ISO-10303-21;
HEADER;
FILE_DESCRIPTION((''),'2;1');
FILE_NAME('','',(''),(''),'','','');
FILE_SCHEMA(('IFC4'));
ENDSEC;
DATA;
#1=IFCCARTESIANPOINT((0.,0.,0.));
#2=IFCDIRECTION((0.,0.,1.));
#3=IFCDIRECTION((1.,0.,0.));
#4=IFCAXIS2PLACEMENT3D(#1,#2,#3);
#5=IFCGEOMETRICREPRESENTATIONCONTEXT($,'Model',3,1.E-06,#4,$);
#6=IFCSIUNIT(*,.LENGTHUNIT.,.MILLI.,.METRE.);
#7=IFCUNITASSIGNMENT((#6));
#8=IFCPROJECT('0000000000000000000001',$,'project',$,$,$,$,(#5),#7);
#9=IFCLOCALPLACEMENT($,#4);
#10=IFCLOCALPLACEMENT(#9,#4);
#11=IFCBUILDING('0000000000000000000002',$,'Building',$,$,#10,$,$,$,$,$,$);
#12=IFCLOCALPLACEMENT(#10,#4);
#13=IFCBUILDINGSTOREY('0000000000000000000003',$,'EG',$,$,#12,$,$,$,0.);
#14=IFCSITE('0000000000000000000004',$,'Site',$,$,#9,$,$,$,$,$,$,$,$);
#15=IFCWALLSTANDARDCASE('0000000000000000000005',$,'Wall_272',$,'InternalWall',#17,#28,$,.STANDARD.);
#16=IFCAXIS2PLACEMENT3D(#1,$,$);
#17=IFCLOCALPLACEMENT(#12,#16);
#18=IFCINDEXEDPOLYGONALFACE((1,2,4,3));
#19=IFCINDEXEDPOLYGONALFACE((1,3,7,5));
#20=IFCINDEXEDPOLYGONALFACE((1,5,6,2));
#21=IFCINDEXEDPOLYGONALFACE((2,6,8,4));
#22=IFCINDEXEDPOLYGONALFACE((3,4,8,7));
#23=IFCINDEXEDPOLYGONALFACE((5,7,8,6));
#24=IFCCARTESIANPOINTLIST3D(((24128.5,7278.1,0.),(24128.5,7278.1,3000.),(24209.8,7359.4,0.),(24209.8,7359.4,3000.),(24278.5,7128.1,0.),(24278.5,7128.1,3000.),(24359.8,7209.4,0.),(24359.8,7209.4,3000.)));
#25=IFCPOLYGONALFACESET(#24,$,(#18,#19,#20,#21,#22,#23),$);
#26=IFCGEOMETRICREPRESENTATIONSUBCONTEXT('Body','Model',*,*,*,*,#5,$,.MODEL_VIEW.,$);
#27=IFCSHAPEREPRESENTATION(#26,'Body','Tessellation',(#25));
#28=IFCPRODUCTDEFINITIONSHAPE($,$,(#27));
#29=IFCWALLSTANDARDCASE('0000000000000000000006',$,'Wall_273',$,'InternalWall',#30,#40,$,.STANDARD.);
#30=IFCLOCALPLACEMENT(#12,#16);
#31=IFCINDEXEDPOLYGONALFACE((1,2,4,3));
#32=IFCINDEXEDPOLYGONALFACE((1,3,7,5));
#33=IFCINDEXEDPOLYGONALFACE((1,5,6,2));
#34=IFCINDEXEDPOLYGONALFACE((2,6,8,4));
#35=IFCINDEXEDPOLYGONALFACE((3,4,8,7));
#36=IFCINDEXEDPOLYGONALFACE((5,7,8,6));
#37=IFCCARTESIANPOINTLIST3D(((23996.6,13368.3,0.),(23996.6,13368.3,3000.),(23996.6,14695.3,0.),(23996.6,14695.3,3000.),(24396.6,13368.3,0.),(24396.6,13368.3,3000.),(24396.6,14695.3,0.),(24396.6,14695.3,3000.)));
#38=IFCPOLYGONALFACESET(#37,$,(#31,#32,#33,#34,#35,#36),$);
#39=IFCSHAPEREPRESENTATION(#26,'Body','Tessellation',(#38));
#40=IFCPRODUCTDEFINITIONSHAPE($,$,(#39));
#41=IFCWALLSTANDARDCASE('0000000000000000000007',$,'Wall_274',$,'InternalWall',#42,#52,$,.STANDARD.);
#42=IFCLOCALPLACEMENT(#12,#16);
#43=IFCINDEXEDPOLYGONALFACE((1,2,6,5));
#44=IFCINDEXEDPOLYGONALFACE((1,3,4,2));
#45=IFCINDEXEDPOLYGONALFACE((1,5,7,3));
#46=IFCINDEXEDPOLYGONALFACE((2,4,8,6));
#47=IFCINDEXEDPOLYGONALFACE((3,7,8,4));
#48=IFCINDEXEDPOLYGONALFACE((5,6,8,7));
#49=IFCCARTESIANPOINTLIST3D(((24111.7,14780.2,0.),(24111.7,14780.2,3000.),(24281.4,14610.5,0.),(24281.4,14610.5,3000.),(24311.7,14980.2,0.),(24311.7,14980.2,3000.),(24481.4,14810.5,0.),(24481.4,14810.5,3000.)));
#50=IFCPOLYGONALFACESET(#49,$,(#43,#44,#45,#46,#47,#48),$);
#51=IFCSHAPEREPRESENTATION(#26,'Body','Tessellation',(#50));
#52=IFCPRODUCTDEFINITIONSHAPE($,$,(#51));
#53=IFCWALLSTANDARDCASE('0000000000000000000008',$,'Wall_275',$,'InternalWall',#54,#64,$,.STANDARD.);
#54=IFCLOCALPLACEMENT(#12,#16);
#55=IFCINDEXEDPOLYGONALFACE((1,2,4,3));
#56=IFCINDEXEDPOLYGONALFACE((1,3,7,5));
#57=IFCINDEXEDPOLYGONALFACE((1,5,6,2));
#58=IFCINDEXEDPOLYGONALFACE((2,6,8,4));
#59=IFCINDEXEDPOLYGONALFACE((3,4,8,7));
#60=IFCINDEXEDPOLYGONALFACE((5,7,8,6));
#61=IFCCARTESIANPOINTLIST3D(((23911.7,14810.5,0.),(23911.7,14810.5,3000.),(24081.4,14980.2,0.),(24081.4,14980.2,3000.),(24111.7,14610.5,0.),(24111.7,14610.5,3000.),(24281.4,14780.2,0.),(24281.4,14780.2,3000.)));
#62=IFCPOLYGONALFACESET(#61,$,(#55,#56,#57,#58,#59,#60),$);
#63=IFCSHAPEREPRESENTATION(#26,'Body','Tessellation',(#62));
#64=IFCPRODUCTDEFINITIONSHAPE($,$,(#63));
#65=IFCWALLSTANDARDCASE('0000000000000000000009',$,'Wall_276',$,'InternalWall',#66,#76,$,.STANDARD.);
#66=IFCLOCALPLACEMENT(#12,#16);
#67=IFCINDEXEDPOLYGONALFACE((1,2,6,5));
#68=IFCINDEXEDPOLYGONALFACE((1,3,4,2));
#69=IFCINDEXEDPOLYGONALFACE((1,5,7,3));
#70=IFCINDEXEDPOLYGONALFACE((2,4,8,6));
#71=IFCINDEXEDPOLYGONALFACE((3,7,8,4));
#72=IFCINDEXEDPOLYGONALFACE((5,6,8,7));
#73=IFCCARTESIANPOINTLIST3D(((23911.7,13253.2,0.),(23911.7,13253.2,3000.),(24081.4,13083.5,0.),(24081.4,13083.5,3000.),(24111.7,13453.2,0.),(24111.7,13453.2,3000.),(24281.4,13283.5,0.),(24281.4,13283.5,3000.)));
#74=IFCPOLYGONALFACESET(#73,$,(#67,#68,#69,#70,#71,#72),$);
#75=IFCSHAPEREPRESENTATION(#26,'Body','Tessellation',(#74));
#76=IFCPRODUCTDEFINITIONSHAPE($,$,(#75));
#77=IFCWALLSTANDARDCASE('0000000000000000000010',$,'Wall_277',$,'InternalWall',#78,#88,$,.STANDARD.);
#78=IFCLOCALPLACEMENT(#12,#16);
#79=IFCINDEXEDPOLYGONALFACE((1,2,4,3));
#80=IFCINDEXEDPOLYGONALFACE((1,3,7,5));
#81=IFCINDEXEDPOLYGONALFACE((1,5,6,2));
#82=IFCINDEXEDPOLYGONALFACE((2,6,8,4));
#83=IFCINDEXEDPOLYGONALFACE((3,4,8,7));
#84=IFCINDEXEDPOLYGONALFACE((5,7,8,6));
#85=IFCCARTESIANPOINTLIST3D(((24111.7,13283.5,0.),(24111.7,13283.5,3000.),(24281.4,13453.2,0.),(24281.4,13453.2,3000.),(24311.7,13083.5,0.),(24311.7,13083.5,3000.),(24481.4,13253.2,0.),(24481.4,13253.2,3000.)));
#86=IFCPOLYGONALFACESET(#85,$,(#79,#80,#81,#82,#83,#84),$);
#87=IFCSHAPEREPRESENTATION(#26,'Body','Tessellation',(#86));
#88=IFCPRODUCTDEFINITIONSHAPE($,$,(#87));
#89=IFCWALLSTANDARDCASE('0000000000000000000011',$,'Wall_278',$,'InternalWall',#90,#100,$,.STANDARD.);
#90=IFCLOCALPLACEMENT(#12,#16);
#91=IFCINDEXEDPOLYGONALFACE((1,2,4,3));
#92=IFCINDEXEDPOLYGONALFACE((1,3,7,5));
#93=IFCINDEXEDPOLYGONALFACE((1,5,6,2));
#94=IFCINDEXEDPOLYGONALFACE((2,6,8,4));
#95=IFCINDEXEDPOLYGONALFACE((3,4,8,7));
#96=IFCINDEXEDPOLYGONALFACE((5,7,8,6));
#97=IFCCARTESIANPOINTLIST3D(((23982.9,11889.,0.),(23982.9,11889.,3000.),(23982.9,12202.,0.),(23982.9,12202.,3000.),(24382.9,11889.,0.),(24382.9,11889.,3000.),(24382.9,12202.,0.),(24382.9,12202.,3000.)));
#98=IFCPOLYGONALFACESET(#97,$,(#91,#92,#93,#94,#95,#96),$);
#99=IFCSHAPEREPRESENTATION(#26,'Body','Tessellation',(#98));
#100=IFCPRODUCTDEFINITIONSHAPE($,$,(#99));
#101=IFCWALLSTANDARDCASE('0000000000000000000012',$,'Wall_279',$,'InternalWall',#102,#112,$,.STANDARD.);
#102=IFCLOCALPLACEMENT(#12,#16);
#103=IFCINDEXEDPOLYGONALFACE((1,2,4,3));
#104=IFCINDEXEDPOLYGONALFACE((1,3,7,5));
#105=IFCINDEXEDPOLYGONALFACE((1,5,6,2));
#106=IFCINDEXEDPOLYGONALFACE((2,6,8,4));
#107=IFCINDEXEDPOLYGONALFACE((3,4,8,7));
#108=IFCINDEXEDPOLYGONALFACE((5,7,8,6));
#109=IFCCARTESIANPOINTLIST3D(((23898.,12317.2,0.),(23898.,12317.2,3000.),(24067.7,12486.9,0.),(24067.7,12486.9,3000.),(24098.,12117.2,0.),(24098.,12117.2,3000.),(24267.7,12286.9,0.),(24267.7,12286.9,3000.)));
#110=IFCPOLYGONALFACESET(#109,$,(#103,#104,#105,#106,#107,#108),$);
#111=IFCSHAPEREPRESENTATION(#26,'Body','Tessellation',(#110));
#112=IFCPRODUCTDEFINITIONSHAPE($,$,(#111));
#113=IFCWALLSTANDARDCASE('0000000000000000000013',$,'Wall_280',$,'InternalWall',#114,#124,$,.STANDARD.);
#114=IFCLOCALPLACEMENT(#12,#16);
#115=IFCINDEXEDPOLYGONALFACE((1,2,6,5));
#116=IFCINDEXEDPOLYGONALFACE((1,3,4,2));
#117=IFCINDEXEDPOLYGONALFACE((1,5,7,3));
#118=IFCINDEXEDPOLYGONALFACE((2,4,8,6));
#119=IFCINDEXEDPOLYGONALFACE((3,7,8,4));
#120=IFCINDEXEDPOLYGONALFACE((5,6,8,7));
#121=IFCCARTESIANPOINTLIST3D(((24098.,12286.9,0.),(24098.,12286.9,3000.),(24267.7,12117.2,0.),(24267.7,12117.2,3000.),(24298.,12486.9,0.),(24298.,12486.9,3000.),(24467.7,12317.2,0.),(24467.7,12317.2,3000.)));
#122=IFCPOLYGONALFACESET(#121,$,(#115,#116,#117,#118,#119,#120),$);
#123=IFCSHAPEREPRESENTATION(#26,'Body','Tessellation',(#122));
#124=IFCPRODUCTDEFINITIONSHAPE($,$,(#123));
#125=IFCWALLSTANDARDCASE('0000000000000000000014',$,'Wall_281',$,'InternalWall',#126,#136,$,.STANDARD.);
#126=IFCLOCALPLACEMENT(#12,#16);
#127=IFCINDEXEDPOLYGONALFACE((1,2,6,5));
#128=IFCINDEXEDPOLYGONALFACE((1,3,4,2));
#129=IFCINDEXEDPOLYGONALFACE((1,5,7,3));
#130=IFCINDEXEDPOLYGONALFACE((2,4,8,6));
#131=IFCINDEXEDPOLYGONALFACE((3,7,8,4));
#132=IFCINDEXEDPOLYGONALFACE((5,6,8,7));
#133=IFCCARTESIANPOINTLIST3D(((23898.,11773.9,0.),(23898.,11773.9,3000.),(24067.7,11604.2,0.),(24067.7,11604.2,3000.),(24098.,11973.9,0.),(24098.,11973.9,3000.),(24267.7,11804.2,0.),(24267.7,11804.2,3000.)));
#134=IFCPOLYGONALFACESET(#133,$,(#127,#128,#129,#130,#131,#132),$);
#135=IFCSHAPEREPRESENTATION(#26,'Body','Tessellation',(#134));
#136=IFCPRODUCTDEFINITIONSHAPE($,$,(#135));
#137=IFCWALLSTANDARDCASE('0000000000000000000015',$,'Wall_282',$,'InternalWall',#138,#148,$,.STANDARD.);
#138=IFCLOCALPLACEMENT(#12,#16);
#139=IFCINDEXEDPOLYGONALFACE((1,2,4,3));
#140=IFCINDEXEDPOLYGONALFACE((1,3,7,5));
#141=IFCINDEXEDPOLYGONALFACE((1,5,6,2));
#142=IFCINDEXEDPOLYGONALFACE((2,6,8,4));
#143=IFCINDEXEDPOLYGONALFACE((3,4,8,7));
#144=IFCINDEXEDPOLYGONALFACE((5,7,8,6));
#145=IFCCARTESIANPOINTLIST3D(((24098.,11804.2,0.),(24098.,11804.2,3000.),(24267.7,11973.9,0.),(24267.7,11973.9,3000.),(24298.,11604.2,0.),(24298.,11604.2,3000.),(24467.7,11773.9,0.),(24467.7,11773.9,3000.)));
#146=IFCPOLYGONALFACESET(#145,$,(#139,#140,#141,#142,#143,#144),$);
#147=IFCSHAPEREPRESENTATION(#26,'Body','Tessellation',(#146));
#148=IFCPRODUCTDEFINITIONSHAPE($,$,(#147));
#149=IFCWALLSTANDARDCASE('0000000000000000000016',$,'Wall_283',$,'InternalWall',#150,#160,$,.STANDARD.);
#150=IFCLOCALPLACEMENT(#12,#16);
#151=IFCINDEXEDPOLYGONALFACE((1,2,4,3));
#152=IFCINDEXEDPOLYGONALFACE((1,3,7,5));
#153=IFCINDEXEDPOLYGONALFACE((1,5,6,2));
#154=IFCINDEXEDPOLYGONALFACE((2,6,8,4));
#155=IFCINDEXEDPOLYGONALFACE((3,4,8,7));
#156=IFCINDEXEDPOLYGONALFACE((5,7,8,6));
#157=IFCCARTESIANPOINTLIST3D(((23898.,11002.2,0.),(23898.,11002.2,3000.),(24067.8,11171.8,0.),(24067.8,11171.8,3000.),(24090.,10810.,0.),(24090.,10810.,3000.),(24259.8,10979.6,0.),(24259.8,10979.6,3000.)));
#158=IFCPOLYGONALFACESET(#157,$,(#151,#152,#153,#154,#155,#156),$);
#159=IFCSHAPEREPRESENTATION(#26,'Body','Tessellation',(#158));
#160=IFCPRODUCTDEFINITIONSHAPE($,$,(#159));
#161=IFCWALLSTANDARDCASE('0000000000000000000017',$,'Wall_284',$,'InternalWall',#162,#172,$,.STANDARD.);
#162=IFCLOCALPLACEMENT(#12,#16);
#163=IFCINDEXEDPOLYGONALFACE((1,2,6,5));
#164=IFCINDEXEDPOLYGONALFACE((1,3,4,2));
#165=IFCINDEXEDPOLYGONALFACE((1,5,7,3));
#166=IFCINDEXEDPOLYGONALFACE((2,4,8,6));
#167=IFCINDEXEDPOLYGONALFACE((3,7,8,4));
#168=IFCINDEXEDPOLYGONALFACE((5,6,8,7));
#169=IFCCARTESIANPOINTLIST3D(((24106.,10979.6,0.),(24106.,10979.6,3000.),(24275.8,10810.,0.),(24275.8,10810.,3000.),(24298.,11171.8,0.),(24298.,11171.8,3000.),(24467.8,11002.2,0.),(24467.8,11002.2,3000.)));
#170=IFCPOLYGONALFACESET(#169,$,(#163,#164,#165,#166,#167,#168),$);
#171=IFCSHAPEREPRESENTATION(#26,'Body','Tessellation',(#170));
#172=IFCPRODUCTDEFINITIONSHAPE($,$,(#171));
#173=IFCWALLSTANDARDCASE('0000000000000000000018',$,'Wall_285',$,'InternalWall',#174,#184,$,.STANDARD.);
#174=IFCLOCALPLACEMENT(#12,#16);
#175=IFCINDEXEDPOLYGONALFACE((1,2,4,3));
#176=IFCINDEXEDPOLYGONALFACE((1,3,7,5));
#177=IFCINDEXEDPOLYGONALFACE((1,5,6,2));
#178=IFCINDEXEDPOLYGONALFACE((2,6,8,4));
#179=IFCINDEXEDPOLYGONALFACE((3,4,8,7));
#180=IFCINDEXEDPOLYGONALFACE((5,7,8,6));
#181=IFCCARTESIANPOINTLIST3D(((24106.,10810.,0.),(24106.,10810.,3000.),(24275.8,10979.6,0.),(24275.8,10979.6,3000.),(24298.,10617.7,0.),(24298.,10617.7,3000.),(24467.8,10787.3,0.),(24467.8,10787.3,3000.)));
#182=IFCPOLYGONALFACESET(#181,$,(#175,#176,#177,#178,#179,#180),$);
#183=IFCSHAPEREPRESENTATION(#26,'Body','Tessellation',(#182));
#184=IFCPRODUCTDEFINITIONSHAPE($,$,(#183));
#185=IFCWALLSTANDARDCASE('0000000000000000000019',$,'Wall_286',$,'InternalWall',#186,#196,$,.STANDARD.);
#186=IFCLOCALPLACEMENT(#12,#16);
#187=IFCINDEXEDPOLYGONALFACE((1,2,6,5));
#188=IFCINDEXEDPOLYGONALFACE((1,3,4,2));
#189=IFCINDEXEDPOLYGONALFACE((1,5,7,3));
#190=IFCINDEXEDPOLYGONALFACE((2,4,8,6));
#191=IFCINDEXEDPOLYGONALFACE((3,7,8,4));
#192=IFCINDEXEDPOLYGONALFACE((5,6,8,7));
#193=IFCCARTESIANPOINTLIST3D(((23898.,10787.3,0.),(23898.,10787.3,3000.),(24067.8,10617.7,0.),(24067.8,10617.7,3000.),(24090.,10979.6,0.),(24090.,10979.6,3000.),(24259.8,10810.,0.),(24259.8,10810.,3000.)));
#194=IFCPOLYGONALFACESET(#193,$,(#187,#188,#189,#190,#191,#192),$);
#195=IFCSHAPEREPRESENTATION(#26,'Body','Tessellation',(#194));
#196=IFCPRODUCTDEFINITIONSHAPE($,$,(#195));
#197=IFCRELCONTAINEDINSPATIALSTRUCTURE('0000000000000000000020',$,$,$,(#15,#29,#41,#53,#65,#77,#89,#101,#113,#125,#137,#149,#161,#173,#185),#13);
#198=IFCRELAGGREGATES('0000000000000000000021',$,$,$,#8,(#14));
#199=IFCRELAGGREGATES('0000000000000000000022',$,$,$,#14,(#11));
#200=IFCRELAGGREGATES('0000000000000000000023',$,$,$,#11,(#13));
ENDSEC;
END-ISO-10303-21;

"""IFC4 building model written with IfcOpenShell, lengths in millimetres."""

from ifc_helpers import new_model, si_unit, frame, origin_with_axes, place, context, subcontext, project, spatial, rectangle, extrude, element, save


model = new_model("IFC4")

# Units and contexts
model_context = context("Model", 3, precision=1e-06, world=origin_with_axes())
body_context = subcontext(model_context, "Body", "Model", "MODEL_VIEW")
ifc_project = project(units=[si_unit("LENGTHUNIT", "METRE", prefix="MILLI")], contexts=[model_context])

# Site, building, storey
site_placement = place(None, origin_with_axes())
site = spatial("IfcSite", under=ifc_project, at=site_placement, Name="Site")
building_placement = place(site_placement, origin_with_axes())
building = spatial("IfcBuilding", under=site, at=building_placement, Name="Building")
storey_placement = place(building_placement, origin_with_axes())
storey = spatial("IfcBuildingStorey", under=building, at=storey_placement, Name="EG", Elevation=0.0)

# Walls
wall_1_placement = place(storey_placement, origin_with_axes())
element("IfcWallStandardCase", 1, at=wall_1_placement, inside=storey, Name="Wall_272", ObjectType="InternalWall", PredefinedType="STANDARD", context=body_context, shape_type="SweptSolid", body=[
    extrude(rectangle(XDim=212.1, YDim=115.0), frame((24244.2, 7243.8, 0.0), z_axis=(0.0, 0.0, 1.0), x_axis=(0.707107, -0.707107, 0.0)), (0.0, 0.0, 1.0), 3000.0),
])
wall_2_placement = place(storey_placement, origin_with_axes())
element("IfcWallStandardCase", 2, at=wall_2_placement, inside=storey, Name="Wall_273", ObjectType="InternalWall", PredefinedType="STANDARD", context=body_context, shape_type="SweptSolid", body=[
    extrude(rectangle(XDim=1327.0, YDim=400.0), frame((24196.6, 14031.8, 0.0), z_axis=(0.0, 0.0, 1.0), x_axis=(0.0, -1.0, 0.0)), (0.0, 0.0, 1.0), 3000.0),
])
wall_3_placement = place(storey_placement, origin_with_axes())
element("IfcWallStandardCase", 3, at=wall_3_placement, inside=storey, Name="Wall_274", ObjectType="InternalWall", PredefinedType="STANDARD", context=body_context, shape_type="SweptSolid", body=[
    extrude(rectangle(XDim=282.8, YDim=240.0), frame((24296.6, 14795.3, 0.0), z_axis=(0.0, 0.0, 1.0), x_axis=(-0.707107, -0.707107, 0.0)), (0.0, 0.0, 1.0), 3000.0),
])
wall_4_placement = place(storey_placement, origin_with_axes())
element("IfcWallStandardCase", 4, at=wall_4_placement, inside=storey, Name="Wall_275", ObjectType="InternalWall", PredefinedType="STANDARD", context=body_context, shape_type="SweptSolid", body=[
    extrude(rectangle(XDim=282.8, YDim=240.0), frame((24096.6, 14795.3, 0.0), z_axis=(0.0, 0.0, 1.0), x_axis=(-0.707107, 0.707107, 0.0)), (0.0, 0.0, 1.0), 3000.0),
])
wall_5_placement = place(storey_placement, origin_with_axes())
element("IfcWallStandardCase", 5, at=wall_5_placement, inside=storey, Name="Wall_276", ObjectType="InternalWall", PredefinedType="STANDARD", context=body_context, shape_type="SweptSolid", body=[
    extrude(rectangle(XDim=282.8, YDim=240.0), frame((24096.6, 13268.3, 0.0), z_axis=(0.0, 0.0, 1.0), x_axis=(-0.707107, -0.707107, 0.0)), (0.0, 0.0, 1.0), 3000.0),
])
wall_6_placement = place(storey_placement, origin_with_axes())
element("IfcWallStandardCase", 6, at=wall_6_placement, inside=storey, Name="Wall_277", ObjectType="InternalWall", PredefinedType="STANDARD", context=body_context, shape_type="SweptSolid", body=[
    extrude(rectangle(XDim=282.8, YDim=240.0), frame((24296.6, 13268.3, 0.0), z_axis=(0.0, 0.0, 1.0), x_axis=(0.707107, -0.707107, 0.0)), (0.0, 0.0, 1.0), 3000.0),
])
wall_7_placement = place(storey_placement, origin_with_axes())
element("IfcWallStandardCase", 7, at=wall_7_placement, inside=storey, Name="Wall_278", ObjectType="InternalWall", PredefinedType="STANDARD", context=body_context, shape_type="SweptSolid", body=[
    extrude(rectangle(XDim=313.0, YDim=400.0), frame((24182.9, 12045.5, 0.0), z_axis=(0.0, 0.0, 1.0), x_axis=(0.0, -1.0, 0.0)), (0.0, 0.0, 1.0), 3000.0),
])
wall_8_placement = place(storey_placement, origin_with_axes())
element("IfcWallStandardCase", 8, at=wall_8_placement, inside=storey, Name="Wall_279", ObjectType="InternalWall", PredefinedType="STANDARD", context=body_context, shape_type="SweptSolid", body=[
    extrude(rectangle(XDim=282.8, YDim=240.0), frame((24082.9, 12302.0, 0.0), z_axis=(0.0, 0.0, 1.0), x_axis=(-0.707107, 0.707107, 0.0)), (0.0, 0.0, 1.0), 3000.0),
])
wall_9_placement = place(storey_placement, origin_with_axes())
element("IfcWallStandardCase", 9, at=wall_9_placement, inside=storey, Name="Wall_280", ObjectType="InternalWall", PredefinedType="STANDARD", context=body_context, shape_type="SweptSolid", body=[
    extrude(rectangle(XDim=282.8, YDim=240.0), frame((24282.9, 12302.0, 0.0), z_axis=(0.0, 0.0, 1.0), x_axis=(0.707107, 0.707107, 0.0)), (0.0, 0.0, 1.0), 3000.0),
])
wall_10_placement = place(storey_placement, origin_with_axes())
element("IfcWallStandardCase", 10, at=wall_10_placement, inside=storey, Name="Wall_281", ObjectType="InternalWall", PredefinedType="STANDARD", context=body_context, shape_type="SweptSolid", body=[
    extrude(rectangle(XDim=282.8, YDim=240.0), frame((24082.9, 11789.0, 0.0), z_axis=(0.0, 0.0, 1.0), x_axis=(-0.707107, -0.707107, 0.0)), (0.0, 0.0, 1.0), 3000.0),
])
wall_11_placement = place(storey_placement, origin_with_axes())
element("IfcWallStandardCase", 11, at=wall_11_placement, inside=storey, Name="Wall_282", ObjectType="InternalWall", PredefinedType="STANDARD", context=body_context, shape_type="SweptSolid", body=[
    extrude(rectangle(XDim=282.8, YDim=240.0), frame((24282.9, 11789.0, 0.0), z_axis=(0.0, 0.0, 1.0), x_axis=(0.707107, -0.707107, 0.0)), (0.0, 0.0, 1.0), 3000.0),
])
wall_12_placement = place(storey_placement, origin_with_axes())
element("IfcWallStandardCase", 12, at=wall_12_placement, inside=storey, Name="Wall_283", ObjectType="InternalWall", PredefinedType="STANDARD", context=body_context, shape_type="SweptSolid", body=[
    extrude(rectangle(XDim=271.7, YDim=240.0), frame((24078.9, 10990.9, 0.0), z_axis=(0.0, 0.0, 1.0), x_axis=(0.706647, -0.707567, 0.0)), (0.0, 0.0, 1.0), 3000.0),
])
wall_13_placement = place(storey_placement, origin_with_axes())
element("IfcWallStandardCase", 13, at=wall_13_placement, inside=storey, Name="Wall_284", ObjectType="InternalWall", PredefinedType="STANDARD", context=body_context, shape_type="SweptSolid", body=[
    extrude(rectangle(XDim=271.7, YDim=240.0), frame((24286.9, 10990.9, 0.0), z_axis=(0.0, 0.0, 1.0), x_axis=(0.706647, 0.707567, 0.0)), (0.0, 0.0, 1.0), 3000.0),
])
wall_14_placement = place(storey_placement, origin_with_axes())
element("IfcWallStandardCase", 14, at=wall_14_placement, inside=storey, Name="Wall_285", ObjectType="InternalWall", PredefinedType="STANDARD", context=body_context, shape_type="SweptSolid", body=[
    extrude(rectangle(XDim=271.7, YDim=240.0), frame((24286.9, 10798.6, 0.0), z_axis=(0.0, 0.0, 1.0), x_axis=(0.706647, -0.707567, 0.0)), (0.0, 0.0, 1.0), 3000.0),
])
wall_15_placement = place(storey_placement, origin_with_axes())
element("IfcWallStandardCase", 15, at=wall_15_placement, inside=storey, Name="Wall_286", ObjectType="InternalWall", PredefinedType="STANDARD", context=body_context, shape_type="SweptSolid", body=[
    extrude(rectangle(XDim=271.7, YDim=240.0), frame((24078.9, 10798.6, 0.0), z_axis=(0.0, 0.0, 1.0), x_axis=(-0.706647, -0.707567, 0.0)), (0.0, 0.0, 1.0), 3000.0),
])

save(model, "model.ifc")
